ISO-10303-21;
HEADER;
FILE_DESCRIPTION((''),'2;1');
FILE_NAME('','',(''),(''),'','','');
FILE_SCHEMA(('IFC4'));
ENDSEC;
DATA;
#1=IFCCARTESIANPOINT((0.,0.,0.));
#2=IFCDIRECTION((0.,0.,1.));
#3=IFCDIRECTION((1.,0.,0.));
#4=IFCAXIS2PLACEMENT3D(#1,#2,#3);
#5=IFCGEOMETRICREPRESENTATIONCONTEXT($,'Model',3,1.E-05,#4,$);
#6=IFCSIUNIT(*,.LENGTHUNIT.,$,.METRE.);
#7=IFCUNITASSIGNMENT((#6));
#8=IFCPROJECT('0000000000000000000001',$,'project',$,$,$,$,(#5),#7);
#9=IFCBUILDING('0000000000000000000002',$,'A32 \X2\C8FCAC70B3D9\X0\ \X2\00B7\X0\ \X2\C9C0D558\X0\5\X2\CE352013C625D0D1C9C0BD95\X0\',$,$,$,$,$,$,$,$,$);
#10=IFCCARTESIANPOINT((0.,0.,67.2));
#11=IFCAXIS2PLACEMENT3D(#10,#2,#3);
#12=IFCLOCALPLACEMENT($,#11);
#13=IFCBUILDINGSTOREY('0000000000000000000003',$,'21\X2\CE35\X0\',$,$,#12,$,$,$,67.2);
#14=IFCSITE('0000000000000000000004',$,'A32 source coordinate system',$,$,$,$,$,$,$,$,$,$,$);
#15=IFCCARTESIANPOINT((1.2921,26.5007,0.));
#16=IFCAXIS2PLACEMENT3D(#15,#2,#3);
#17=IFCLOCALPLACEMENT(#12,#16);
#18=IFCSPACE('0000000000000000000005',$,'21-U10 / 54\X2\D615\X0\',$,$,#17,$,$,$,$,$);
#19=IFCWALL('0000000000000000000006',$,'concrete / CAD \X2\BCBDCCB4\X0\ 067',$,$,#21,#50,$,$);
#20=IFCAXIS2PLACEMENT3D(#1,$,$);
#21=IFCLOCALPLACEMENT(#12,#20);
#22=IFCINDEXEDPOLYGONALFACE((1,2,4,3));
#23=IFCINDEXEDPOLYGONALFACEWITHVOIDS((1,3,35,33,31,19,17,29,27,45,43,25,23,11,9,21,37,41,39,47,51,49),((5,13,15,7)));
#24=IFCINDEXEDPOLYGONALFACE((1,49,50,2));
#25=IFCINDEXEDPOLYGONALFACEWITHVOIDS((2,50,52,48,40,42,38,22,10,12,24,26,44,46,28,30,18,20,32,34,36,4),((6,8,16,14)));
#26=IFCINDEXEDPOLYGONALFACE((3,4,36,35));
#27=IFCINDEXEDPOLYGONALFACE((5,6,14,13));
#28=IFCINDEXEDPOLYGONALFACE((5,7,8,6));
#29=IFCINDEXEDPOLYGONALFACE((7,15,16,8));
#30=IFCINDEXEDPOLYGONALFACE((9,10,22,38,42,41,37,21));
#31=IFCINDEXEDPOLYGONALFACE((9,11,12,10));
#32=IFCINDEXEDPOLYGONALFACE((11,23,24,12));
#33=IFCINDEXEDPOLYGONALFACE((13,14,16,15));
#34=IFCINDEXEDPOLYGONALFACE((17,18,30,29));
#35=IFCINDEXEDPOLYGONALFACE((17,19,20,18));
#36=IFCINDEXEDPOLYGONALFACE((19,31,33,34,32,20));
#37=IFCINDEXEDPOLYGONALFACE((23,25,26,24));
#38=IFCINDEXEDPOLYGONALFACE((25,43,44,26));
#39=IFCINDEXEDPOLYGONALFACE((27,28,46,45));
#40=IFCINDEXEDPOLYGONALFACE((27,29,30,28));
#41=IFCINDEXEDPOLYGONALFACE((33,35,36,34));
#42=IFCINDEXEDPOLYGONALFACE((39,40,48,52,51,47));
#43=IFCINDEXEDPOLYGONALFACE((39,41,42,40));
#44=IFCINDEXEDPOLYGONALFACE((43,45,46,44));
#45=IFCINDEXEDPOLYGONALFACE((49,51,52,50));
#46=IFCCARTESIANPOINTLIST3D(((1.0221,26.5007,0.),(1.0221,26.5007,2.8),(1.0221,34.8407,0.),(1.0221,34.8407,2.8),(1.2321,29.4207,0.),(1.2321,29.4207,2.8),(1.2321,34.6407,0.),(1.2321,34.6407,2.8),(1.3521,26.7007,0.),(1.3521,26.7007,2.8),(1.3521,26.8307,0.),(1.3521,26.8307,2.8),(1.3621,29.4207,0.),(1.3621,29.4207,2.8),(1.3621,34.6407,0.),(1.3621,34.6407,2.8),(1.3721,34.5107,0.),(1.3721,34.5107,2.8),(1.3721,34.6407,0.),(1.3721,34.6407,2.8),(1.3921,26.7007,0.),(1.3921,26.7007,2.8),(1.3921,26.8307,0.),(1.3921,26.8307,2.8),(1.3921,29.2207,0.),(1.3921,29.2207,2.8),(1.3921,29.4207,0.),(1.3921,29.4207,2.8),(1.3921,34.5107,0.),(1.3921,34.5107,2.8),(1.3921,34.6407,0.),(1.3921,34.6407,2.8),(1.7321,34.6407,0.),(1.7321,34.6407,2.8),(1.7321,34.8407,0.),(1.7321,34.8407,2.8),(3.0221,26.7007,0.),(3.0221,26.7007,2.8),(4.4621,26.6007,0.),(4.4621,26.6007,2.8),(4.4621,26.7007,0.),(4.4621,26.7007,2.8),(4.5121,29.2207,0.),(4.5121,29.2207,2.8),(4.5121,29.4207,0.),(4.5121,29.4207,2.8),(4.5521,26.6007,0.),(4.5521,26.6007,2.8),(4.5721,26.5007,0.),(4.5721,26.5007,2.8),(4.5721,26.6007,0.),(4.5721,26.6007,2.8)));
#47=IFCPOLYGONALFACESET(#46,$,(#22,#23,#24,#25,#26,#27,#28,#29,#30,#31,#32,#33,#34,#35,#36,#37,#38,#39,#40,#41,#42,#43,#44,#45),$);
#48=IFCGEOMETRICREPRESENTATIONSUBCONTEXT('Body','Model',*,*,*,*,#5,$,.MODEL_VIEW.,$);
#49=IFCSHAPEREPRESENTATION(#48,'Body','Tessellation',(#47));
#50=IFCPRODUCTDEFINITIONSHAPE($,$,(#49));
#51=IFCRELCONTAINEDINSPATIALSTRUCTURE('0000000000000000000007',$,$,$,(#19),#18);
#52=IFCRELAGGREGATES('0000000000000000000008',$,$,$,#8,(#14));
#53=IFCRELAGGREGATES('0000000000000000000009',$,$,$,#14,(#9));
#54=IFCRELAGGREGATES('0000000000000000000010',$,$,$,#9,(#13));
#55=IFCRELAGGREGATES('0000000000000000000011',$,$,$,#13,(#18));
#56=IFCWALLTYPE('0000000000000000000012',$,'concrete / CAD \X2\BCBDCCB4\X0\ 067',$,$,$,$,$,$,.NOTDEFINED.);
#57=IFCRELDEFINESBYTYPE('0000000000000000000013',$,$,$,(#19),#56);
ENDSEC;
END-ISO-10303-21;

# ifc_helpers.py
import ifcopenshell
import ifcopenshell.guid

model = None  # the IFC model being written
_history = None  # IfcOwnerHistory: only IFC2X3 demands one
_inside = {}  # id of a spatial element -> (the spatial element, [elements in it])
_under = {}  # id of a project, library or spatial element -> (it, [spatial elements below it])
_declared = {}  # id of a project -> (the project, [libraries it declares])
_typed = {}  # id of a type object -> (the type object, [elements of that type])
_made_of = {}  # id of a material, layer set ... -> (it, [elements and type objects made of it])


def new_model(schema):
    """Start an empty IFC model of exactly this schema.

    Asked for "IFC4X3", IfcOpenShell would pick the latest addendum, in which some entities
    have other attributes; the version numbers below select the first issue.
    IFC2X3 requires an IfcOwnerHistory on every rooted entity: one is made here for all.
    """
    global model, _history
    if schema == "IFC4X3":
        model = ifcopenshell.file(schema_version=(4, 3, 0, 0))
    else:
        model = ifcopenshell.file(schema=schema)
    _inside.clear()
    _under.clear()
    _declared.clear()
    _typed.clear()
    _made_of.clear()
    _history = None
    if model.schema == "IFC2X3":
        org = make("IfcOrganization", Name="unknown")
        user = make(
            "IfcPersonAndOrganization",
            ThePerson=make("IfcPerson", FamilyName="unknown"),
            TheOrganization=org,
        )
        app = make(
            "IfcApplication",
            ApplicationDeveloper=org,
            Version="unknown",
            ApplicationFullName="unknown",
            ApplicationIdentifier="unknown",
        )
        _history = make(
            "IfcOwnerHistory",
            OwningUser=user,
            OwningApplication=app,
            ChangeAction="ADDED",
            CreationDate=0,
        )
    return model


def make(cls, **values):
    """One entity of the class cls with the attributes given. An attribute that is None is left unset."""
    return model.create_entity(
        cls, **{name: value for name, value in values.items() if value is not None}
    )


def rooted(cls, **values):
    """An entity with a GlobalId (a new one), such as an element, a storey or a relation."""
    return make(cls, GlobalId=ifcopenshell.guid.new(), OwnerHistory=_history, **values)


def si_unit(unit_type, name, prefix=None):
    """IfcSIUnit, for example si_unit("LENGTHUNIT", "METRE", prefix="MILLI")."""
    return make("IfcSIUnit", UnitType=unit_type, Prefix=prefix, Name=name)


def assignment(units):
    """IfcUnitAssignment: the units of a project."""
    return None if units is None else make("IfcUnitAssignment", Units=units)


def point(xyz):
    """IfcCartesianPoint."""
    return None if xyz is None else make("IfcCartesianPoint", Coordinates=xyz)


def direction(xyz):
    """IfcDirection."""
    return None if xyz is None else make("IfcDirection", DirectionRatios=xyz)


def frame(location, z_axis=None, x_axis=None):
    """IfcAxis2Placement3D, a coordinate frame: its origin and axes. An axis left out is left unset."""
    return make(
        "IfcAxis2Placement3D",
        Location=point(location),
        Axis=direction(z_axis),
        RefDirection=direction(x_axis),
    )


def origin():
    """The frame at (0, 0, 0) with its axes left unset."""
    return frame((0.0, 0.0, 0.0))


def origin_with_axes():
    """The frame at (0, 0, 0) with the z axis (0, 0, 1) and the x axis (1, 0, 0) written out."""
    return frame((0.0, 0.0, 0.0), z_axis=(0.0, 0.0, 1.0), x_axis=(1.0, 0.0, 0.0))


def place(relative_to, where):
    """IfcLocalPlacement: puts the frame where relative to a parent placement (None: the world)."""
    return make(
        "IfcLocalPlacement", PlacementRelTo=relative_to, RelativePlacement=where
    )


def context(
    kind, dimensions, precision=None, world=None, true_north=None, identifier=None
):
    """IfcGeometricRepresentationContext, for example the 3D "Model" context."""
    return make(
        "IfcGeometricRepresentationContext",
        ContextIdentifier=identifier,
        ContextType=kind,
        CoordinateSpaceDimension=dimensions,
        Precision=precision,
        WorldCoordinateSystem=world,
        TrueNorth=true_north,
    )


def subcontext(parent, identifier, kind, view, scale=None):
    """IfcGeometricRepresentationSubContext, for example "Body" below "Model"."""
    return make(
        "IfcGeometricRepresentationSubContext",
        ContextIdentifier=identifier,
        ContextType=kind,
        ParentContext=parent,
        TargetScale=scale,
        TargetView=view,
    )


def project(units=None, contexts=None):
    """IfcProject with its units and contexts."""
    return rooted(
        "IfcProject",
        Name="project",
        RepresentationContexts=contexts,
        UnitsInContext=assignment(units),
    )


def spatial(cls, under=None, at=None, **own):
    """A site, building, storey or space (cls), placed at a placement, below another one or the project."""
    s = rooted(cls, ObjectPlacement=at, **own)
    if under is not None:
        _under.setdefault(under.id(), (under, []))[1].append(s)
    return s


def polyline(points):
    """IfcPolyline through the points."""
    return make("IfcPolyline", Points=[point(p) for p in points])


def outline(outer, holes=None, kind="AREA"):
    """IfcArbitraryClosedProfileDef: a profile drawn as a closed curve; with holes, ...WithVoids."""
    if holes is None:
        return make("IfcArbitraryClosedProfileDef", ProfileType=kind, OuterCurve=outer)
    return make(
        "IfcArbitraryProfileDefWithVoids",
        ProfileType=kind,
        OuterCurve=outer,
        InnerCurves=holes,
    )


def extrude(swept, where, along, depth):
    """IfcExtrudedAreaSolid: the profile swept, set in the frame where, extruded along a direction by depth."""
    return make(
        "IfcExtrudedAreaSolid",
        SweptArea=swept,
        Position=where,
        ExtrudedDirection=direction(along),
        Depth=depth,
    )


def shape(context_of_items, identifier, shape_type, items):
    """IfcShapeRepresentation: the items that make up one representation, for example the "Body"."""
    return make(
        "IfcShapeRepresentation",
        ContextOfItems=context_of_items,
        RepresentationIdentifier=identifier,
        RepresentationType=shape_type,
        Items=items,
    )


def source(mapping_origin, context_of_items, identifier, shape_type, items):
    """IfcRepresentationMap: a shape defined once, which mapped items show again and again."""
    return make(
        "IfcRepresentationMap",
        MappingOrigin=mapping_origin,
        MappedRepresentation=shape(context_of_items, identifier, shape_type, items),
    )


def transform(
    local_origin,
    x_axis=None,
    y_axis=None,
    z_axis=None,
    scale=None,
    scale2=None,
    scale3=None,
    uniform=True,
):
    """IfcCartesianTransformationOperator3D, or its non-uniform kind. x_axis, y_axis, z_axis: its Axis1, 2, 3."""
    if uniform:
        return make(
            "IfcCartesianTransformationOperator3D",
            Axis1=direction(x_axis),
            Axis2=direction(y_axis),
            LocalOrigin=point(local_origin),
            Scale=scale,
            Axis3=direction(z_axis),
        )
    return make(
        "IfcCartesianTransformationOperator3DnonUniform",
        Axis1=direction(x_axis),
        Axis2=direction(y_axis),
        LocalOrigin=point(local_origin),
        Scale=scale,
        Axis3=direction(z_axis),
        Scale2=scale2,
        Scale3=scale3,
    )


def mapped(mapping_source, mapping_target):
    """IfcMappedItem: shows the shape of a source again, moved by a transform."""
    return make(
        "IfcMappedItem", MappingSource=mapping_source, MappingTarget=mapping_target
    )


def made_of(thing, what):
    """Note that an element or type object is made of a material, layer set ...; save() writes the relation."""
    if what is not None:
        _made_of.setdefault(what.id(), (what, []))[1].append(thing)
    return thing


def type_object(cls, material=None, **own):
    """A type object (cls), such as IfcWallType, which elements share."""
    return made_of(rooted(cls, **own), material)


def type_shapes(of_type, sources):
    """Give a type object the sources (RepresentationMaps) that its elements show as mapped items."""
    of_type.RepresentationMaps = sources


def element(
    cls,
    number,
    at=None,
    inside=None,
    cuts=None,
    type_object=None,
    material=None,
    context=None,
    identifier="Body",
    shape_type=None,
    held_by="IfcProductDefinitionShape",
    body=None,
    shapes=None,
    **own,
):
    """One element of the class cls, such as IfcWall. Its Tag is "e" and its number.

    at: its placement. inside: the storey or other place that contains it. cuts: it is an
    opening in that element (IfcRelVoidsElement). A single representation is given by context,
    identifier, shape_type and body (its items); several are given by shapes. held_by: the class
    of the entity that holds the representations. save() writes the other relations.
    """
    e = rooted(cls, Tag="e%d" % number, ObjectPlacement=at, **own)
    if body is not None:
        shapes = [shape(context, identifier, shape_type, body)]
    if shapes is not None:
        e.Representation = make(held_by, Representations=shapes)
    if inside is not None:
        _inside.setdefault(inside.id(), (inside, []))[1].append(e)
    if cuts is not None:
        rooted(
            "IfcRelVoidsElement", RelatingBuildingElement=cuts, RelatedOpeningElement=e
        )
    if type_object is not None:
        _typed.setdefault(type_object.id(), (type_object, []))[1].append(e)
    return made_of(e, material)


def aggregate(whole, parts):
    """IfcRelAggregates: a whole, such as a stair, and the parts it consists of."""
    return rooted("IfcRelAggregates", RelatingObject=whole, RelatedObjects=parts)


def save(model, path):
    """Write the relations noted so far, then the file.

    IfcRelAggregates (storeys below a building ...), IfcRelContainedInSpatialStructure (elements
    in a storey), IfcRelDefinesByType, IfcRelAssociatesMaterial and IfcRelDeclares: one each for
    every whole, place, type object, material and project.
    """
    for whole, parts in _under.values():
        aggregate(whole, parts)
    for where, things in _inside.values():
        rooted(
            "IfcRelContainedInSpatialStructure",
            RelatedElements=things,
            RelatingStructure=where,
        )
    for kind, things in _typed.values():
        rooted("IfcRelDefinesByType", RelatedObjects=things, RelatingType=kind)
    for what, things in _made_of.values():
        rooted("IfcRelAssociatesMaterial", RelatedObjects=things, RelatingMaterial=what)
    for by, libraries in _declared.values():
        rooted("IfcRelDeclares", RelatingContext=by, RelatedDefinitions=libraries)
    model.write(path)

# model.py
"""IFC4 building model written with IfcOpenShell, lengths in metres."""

from ifc_helpers import new_model, si_unit, frame, origin, origin_with_axes, place, context, subcontext, project, spatial, polyline, outline, extrude, source, transform, mapped, type_object, type_shapes, element, save


model = new_model("IFC4")

# Units and contexts
model_context = context("Model", 3, precision=1e-05, world=origin_with_axes())
body_context = subcontext(model_context, "Body", "Model", "MODEL_VIEW")
ifc_project = project(units=[si_unit("LENGTHUNIT", "METRE")], contexts=[model_context])

# Site, building, storey, space
site = spatial("IfcSite", under=ifc_project, Name="A32 source coordinate system")
building = spatial("IfcBuilding", under=site, Name="A32 주거동 · 지하5층–옥탑지붕")
storey_placement = place(None, frame((0.0, 0.0, 67.2), z_axis=(0.0, 0.0, 1.0), x_axis=(1.0, 0.0, 0.0)))
storey = spatial("IfcBuildingStorey", under=building, at=storey_placement, Name="21층", Elevation=67.2)
space_placement = place(storey_placement, frame((1.2921, 26.5007, 0.0), z_axis=(0.0, 0.0, 1.0), x_axis=(1.0, 0.0, 0.0)))
space = spatial("IfcSpace", under=storey, at=space_placement, Name="21-U10 / 54형")

# Wall
wall_type_1 = type_object("IfcWallType", Name="concrete / CAD 벽체 067", PredefinedType="NOTDEFINED")
shared_shape_1 = source(origin(), body_context, "Body", "SweptSolid", [
    extrude(outline(polyline([(0.1, 0.2), (1.73, 0.2), (3.17, 0.2), (3.17, 0.1), (3.26, 0.1), (3.28, 0.1), (3.28, 0.0), (-0.27, 0.0), (-0.27, 8.34), (0.44, 8.34), (0.44, 8.14), (0.1, 8.14), (0.08, 8.14), (0.08, 8.01), (0.1, 8.01), (0.1, 2.92), (3.22, 2.92), (3.22, 2.72), (0.1, 2.72), (0.1, 0.33), (0.06, 0.33), (0.06, 0.2), (0.1, 0.2)]), holes=[polyline([(-0.06, 8.14), (-0.06, 2.92), (0.07, 2.92), (0.07, 8.14), (-0.06, 8.14)])]), origin(), (0.0, 0.0, 1.0), 2.8),
])
type_shapes(wall_type_1, [shared_shape_1])
wall_1_placement = place(space_placement, origin_with_axes())
element("IfcWall", 1, at=wall_1_placement, inside=space, type_object=wall_type_1, Name="concrete / CAD 벽체 067", context=body_context, shape_type="MappedRepresentation", body=[
    mapped(shared_shape_1, transform((0.0, 0.0, 0.0), scale=1.0)),
])

save(model, "model.ifc")
